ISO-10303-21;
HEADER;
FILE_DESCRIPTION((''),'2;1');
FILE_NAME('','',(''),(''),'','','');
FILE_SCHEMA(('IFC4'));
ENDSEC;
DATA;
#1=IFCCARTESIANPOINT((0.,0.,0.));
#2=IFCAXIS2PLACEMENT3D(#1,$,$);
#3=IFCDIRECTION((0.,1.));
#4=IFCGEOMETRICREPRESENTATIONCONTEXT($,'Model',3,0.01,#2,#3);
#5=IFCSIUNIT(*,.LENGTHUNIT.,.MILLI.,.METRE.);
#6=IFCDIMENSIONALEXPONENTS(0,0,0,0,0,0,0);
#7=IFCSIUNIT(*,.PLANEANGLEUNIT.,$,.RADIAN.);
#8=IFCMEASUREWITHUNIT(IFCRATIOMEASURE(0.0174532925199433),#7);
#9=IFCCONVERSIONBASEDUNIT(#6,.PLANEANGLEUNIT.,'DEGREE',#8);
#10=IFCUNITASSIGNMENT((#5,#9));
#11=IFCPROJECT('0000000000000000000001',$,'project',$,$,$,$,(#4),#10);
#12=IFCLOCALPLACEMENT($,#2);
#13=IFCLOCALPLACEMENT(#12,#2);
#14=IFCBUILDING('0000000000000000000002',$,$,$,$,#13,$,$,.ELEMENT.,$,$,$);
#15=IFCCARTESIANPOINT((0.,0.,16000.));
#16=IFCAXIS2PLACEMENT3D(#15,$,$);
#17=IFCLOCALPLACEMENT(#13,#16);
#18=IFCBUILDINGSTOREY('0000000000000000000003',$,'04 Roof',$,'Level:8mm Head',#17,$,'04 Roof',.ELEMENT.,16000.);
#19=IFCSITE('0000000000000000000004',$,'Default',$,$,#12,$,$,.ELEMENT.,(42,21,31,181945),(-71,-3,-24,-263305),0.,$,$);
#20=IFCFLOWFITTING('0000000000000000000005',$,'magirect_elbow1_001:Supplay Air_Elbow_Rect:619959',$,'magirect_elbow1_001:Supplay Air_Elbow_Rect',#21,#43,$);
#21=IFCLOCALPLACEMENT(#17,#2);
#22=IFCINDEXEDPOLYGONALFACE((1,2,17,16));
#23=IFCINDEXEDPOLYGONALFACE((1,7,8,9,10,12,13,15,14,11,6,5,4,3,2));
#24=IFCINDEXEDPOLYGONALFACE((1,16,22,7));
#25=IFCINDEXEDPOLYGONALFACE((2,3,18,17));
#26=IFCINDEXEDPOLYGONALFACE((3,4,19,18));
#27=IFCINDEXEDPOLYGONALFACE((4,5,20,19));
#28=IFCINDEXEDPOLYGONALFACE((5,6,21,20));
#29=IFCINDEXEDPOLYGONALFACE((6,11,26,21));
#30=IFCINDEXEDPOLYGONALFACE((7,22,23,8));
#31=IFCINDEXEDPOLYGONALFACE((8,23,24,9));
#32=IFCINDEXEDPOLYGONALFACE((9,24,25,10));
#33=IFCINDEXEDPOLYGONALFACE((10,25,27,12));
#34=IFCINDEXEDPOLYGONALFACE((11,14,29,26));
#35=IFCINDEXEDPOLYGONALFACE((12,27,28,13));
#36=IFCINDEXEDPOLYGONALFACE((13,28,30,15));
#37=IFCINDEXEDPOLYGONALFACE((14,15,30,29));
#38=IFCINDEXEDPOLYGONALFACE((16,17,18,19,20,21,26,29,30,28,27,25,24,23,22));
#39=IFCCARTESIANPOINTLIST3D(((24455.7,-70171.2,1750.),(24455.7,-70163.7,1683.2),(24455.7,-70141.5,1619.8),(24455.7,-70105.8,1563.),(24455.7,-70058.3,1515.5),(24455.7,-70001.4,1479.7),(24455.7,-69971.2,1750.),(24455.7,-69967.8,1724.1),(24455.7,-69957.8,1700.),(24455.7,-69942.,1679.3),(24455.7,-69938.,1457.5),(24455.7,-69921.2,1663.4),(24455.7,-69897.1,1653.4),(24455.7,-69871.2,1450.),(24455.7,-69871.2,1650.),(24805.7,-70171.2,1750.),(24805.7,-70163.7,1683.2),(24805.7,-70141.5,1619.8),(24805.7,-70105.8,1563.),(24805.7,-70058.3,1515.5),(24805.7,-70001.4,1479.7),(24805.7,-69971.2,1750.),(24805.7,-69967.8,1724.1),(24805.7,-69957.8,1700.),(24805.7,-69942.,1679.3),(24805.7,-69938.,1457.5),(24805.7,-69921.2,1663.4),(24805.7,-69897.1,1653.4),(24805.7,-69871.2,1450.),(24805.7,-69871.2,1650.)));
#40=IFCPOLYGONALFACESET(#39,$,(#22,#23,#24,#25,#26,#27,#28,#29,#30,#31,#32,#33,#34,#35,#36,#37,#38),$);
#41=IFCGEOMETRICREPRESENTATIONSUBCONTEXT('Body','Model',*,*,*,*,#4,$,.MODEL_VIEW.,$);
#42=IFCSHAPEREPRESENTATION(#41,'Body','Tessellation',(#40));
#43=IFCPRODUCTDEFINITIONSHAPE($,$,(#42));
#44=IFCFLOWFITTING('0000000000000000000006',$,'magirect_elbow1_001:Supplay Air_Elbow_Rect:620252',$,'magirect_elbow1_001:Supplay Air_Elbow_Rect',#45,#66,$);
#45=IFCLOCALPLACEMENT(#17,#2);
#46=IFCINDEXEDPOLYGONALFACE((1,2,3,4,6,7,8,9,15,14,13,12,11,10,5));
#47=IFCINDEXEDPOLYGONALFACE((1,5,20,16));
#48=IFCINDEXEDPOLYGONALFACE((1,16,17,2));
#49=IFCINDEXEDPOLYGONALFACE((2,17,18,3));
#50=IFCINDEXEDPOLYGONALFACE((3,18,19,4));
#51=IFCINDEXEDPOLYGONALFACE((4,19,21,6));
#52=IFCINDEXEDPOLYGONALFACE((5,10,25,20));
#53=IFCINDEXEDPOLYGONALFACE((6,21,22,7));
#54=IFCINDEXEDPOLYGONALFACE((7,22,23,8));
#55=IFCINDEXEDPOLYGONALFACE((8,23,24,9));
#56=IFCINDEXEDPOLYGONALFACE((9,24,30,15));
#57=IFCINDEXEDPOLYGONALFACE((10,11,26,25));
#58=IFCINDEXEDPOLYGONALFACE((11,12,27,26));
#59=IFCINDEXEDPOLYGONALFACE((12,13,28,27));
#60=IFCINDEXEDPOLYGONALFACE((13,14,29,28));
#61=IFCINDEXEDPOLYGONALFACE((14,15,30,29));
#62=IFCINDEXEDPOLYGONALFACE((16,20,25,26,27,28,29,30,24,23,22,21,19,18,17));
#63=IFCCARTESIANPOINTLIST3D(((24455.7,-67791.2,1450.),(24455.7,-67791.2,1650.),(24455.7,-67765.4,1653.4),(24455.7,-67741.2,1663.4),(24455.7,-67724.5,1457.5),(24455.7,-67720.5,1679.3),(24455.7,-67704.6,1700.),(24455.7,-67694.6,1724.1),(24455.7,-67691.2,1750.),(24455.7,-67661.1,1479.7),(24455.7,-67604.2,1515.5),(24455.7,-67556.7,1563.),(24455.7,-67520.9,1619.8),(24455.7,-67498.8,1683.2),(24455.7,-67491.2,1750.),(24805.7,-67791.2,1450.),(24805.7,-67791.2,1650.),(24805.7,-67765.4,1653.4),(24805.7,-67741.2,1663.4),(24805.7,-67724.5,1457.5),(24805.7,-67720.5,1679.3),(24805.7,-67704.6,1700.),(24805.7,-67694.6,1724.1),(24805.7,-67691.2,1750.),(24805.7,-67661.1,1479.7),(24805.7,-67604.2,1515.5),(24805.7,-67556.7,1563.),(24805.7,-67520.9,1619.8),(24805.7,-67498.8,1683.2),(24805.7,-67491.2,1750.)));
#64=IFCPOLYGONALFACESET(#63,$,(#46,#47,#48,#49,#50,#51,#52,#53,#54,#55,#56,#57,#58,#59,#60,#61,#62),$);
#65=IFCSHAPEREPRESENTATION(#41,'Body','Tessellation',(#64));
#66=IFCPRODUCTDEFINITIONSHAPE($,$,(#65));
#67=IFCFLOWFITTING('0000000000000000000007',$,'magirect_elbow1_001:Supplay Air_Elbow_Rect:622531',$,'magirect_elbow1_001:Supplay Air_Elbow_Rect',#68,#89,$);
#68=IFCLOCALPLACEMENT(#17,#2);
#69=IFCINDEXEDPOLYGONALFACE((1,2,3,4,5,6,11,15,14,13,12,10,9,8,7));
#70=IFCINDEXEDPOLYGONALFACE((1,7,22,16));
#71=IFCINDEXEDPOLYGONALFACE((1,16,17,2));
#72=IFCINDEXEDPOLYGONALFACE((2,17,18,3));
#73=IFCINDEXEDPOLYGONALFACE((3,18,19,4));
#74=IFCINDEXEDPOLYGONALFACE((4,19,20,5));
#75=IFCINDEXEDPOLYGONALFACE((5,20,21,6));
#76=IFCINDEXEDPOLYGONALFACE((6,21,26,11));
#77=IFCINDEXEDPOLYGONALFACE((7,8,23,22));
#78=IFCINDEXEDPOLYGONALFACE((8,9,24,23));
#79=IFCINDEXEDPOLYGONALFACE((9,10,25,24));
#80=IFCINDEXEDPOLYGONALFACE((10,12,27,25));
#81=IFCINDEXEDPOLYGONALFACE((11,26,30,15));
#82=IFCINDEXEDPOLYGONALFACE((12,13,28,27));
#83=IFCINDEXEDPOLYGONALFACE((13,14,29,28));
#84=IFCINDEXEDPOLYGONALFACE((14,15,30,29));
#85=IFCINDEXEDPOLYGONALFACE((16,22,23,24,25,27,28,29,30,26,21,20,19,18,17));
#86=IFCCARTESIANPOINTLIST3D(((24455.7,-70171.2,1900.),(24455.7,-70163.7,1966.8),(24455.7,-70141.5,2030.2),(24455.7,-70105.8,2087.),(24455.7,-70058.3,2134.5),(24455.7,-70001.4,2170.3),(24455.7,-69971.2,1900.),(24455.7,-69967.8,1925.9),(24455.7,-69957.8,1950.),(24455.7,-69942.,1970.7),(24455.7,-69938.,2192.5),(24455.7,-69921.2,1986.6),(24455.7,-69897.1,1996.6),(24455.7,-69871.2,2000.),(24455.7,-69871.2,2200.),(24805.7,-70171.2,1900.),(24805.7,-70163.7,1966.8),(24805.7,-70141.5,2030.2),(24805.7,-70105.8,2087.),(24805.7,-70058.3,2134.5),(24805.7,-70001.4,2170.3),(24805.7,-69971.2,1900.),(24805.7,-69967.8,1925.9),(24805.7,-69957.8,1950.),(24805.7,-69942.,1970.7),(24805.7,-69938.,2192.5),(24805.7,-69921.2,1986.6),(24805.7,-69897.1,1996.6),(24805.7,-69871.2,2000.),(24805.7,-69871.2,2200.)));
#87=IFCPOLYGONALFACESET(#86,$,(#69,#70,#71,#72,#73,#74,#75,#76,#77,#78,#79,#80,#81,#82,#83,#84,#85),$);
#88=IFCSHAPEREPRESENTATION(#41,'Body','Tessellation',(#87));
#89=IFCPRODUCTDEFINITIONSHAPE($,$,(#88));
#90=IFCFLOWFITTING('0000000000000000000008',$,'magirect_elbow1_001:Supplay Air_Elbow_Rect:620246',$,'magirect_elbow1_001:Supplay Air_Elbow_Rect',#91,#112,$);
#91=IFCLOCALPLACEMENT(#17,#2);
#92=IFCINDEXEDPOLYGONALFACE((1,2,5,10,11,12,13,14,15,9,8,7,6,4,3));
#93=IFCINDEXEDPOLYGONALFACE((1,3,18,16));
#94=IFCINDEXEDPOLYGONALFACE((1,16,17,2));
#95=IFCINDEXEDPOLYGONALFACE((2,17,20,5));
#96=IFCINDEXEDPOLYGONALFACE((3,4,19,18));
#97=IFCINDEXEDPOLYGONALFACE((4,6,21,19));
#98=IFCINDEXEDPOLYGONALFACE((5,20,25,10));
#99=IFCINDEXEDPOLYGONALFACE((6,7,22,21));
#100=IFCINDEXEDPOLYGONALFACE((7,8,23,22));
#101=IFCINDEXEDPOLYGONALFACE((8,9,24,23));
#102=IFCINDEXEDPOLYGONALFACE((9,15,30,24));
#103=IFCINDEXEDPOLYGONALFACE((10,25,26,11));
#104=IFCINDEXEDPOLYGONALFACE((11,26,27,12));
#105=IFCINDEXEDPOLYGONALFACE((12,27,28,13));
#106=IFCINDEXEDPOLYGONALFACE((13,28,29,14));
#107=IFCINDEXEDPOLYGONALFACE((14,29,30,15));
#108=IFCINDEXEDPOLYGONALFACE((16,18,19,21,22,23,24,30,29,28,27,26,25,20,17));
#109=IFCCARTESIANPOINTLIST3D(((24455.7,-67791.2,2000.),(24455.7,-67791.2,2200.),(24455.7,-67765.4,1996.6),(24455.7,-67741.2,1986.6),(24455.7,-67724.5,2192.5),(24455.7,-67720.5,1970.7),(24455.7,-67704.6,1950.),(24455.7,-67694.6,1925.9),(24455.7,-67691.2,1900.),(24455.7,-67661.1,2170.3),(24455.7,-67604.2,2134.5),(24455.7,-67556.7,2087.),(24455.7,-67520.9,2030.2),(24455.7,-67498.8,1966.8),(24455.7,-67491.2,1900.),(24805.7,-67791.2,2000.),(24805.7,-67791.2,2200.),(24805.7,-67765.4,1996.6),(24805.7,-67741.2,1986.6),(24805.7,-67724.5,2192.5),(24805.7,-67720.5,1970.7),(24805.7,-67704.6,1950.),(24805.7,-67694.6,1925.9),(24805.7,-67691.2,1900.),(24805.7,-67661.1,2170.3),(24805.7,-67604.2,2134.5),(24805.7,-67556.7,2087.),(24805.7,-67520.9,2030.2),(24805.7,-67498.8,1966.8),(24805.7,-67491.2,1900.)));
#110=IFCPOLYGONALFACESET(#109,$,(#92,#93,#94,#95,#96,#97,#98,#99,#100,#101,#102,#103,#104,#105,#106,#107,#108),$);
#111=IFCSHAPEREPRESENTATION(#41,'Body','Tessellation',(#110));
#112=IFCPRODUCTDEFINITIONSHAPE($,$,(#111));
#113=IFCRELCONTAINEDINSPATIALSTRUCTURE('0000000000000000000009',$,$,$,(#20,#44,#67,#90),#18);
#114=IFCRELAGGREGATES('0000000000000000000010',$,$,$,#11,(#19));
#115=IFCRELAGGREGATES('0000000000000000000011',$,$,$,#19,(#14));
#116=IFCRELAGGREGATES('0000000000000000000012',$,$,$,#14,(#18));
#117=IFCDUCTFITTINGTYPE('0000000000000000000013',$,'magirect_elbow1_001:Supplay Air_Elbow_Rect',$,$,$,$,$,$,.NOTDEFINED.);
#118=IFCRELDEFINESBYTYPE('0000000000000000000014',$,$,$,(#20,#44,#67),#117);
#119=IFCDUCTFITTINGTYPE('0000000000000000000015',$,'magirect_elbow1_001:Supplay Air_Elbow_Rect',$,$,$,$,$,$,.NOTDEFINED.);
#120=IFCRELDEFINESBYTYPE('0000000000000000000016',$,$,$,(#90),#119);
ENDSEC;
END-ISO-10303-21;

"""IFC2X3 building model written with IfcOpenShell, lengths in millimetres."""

from ifc_helpers import new_model, entity, si_unit, converted_unit, direction, frame, frame_2d, origin, place, context, subcontext, project, spatial, polyline, circle_curve, parameter, trimmed, segment, composite_curve, outline, extrude, source, transform, mapped, type_object, type_shapes, element, save


model = new_model("IFC2X3")

# Units and contexts
model_context = context("Model", 3, precision=0.01, world=origin(), true_north=direction((0.0, 1.0)))
body_context = subcontext(model_context, "Body", "Model", "MODEL_VIEW")
ifc_project = project(units=[si_unit("LENGTHUNIT", "METRE", prefix="MILLI"), converted_unit("PLANEANGLEUNIT", "DEGREE", entity("IfcRatioMeasure", 0.0174532925199433), si_unit("PLANEANGLEUNIT", "RADIAN"), dimensions=[0, 0, 0, 0, 0, 0, 0])], contexts=[model_context])

# Site, building, storey
site_placement = place(None, origin())
site = spatial("IfcSite", under=ifc_project, at=site_placement, Name="Default", CompositionType="ELEMENT", RefLatitude=(42, 21, 31, 181945), RefLongitude=(-71, -3, -24, -263305), RefElevation=0.0)
building_placement = place(site_placement, origin())
building = spatial("IfcBuilding", under=site, at=building_placement, CompositionType="ELEMENT")
storey_placement = place(building_placement, frame((0.0, 0.0, 16000.0)))
storey = spatial("IfcBuildingStorey", under=building, at=storey_placement, Name="04 Roof", ObjectType="Level:8mm Head", LongName="04 Roof", CompositionType="ELEMENT", Elevation=16000.0)

# Flow fittings
duct_fitting_type_1 = type_object("IfcDuctFittingType", Name="magirect_elbow1_001:Supplay Air_Elbow_Rect", PredefinedType="NOTDEFINED")
shared_shape_1 = source(origin(), body_context, "Body", "SweptSolid", [
    extrude(outline(composite_curve([segment(polyline([(-200.0, -100.0), (0.0, -100.0)]), True, "CONTINUOUS"), segment(trimmed(circle_curve(frame_2d((100.0, -100.0), x_axis=(0.0, 1.0)), 100.0), [parameter(0.0)], [parameter(90.0)], True, "PARAMETER"), False, "CONTINUOUS"), segment(polyline([(100.0, 0.0), (100.0, 200.0)]), True, "CONTINUOUS"), segment(trimmed(circle_curve(frame_2d((100.0, -100.0), x_axis=(0.0, 1.0)), 300.0), [parameter(0.0)], [parameter(90.0)], True, "PARAMETER"), True, "CONTINUOUS")], self_intersect=False)), frame((-100.0, 100.0, -175.0), z_axis=(0.0, 0.0, 1.0), x_axis=(-1.0, 0.0, 0.0)), (0.0, 0.0, 1.0), 350.0),
])
type_shapes(duct_fitting_type_1, [shared_shape_1])
for number, where, z_axis, x_axis, name in (
    (1, (24630.7, -70071.2, 1550.0), (-1.0, 0.0, 0.0), (0.0, -1.0, 0.0), "magirect_elbow1_001:Supplay Air_Elbow_Rect:619959"),
    (2, (24630.7, -67591.2, 1550.0), (-1.0, 0.0, 0.0), (0.0, 0.0, -1.0), "magirect_elbow1_001:Supplay Air_Elbow_Rect:620252"),
    (3, (24630.7, -70071.2, 2100.0), (-1.0, 0.0, 0.0), (0.0, 0.0, 1.0), "magirect_elbow1_001:Supplay Air_Elbow_Rect:622531"),
):
    element("IfcFlowFitting", number, at=place(storey_placement, frame(where, z_axis=z_axis, x_axis=x_axis)), inside=storey, type_object=duct_fitting_type_1, Name=name, ObjectType="magirect_elbow1_001:Supplay Air_Elbow_Rect", context=body_context, shape_type="MappedRepresentation", body=[
        mapped(shared_shape_1, transform((0.0, 0.0, 0.0), scale=1.0)),
    ])
duct_fitting_type_2 = type_object("IfcDuctFittingType", Name="magirect_elbow1_001:Supplay Air_Elbow_Rect", PredefinedType="NOTDEFINED")
shared_shape_2 = source(origin(), body_context, "Body", "SweptSolid", [
    extrude(outline(composite_curve([segment(trimmed(circle_curve(frame_2d((-100.0, 100.0), x_axis=(1.0, 0.0)), 300.0), [parameter(270.0)], [parameter(0.0)], True, "PARAMETER"), True, "CONTINUOUS"), segment(polyline([(200.0, 100.0), (0.0, 100.0)]), True, "CONTINUOUS"), segment(trimmed(circle_curve(frame_2d((-100.0, 100.0), x_axis=(1.0, 0.0)), 100.0), [parameter(270.0)], [parameter(0.0)], True, "PARAMETER"), False, "CONTINUOUS"), segment(polyline([(-100.0, 0.0), (-100.0, -200.0)]), True, "CONTINUOUS")], self_intersect=False)), frame((-100.0, -100.0, -175.0), z_axis=(0.0, 0.0, 1.0), x_axis=(0.0, 1.0, 0.0)), (0.0, 0.0, 1.0), 350.0),
])
type_shapes(duct_fitting_type_2, [shared_shape_2])
flow_fitting_1_placement = place(storey_placement, frame((24630.7, -67591.2, 2100.0), z_axis=(-1.0, 0.0, 0.0), x_axis=(0.0, 0.0, 1.0)))
element("IfcFlowFitting", 4, at=flow_fitting_1_placement, inside=storey, type_object=duct_fitting_type_2, Name="magirect_elbow1_001:Supplay Air_Elbow_Rect:620246", ObjectType="magirect_elbow1_001:Supplay Air_Elbow_Rect", context=body_context, shape_type="MappedRepresentation", body=[
    mapped(shared_shape_2, transform((0.0, 0.0, 0.0), scale=1.0)),
])

save(model, "model.ifc")
